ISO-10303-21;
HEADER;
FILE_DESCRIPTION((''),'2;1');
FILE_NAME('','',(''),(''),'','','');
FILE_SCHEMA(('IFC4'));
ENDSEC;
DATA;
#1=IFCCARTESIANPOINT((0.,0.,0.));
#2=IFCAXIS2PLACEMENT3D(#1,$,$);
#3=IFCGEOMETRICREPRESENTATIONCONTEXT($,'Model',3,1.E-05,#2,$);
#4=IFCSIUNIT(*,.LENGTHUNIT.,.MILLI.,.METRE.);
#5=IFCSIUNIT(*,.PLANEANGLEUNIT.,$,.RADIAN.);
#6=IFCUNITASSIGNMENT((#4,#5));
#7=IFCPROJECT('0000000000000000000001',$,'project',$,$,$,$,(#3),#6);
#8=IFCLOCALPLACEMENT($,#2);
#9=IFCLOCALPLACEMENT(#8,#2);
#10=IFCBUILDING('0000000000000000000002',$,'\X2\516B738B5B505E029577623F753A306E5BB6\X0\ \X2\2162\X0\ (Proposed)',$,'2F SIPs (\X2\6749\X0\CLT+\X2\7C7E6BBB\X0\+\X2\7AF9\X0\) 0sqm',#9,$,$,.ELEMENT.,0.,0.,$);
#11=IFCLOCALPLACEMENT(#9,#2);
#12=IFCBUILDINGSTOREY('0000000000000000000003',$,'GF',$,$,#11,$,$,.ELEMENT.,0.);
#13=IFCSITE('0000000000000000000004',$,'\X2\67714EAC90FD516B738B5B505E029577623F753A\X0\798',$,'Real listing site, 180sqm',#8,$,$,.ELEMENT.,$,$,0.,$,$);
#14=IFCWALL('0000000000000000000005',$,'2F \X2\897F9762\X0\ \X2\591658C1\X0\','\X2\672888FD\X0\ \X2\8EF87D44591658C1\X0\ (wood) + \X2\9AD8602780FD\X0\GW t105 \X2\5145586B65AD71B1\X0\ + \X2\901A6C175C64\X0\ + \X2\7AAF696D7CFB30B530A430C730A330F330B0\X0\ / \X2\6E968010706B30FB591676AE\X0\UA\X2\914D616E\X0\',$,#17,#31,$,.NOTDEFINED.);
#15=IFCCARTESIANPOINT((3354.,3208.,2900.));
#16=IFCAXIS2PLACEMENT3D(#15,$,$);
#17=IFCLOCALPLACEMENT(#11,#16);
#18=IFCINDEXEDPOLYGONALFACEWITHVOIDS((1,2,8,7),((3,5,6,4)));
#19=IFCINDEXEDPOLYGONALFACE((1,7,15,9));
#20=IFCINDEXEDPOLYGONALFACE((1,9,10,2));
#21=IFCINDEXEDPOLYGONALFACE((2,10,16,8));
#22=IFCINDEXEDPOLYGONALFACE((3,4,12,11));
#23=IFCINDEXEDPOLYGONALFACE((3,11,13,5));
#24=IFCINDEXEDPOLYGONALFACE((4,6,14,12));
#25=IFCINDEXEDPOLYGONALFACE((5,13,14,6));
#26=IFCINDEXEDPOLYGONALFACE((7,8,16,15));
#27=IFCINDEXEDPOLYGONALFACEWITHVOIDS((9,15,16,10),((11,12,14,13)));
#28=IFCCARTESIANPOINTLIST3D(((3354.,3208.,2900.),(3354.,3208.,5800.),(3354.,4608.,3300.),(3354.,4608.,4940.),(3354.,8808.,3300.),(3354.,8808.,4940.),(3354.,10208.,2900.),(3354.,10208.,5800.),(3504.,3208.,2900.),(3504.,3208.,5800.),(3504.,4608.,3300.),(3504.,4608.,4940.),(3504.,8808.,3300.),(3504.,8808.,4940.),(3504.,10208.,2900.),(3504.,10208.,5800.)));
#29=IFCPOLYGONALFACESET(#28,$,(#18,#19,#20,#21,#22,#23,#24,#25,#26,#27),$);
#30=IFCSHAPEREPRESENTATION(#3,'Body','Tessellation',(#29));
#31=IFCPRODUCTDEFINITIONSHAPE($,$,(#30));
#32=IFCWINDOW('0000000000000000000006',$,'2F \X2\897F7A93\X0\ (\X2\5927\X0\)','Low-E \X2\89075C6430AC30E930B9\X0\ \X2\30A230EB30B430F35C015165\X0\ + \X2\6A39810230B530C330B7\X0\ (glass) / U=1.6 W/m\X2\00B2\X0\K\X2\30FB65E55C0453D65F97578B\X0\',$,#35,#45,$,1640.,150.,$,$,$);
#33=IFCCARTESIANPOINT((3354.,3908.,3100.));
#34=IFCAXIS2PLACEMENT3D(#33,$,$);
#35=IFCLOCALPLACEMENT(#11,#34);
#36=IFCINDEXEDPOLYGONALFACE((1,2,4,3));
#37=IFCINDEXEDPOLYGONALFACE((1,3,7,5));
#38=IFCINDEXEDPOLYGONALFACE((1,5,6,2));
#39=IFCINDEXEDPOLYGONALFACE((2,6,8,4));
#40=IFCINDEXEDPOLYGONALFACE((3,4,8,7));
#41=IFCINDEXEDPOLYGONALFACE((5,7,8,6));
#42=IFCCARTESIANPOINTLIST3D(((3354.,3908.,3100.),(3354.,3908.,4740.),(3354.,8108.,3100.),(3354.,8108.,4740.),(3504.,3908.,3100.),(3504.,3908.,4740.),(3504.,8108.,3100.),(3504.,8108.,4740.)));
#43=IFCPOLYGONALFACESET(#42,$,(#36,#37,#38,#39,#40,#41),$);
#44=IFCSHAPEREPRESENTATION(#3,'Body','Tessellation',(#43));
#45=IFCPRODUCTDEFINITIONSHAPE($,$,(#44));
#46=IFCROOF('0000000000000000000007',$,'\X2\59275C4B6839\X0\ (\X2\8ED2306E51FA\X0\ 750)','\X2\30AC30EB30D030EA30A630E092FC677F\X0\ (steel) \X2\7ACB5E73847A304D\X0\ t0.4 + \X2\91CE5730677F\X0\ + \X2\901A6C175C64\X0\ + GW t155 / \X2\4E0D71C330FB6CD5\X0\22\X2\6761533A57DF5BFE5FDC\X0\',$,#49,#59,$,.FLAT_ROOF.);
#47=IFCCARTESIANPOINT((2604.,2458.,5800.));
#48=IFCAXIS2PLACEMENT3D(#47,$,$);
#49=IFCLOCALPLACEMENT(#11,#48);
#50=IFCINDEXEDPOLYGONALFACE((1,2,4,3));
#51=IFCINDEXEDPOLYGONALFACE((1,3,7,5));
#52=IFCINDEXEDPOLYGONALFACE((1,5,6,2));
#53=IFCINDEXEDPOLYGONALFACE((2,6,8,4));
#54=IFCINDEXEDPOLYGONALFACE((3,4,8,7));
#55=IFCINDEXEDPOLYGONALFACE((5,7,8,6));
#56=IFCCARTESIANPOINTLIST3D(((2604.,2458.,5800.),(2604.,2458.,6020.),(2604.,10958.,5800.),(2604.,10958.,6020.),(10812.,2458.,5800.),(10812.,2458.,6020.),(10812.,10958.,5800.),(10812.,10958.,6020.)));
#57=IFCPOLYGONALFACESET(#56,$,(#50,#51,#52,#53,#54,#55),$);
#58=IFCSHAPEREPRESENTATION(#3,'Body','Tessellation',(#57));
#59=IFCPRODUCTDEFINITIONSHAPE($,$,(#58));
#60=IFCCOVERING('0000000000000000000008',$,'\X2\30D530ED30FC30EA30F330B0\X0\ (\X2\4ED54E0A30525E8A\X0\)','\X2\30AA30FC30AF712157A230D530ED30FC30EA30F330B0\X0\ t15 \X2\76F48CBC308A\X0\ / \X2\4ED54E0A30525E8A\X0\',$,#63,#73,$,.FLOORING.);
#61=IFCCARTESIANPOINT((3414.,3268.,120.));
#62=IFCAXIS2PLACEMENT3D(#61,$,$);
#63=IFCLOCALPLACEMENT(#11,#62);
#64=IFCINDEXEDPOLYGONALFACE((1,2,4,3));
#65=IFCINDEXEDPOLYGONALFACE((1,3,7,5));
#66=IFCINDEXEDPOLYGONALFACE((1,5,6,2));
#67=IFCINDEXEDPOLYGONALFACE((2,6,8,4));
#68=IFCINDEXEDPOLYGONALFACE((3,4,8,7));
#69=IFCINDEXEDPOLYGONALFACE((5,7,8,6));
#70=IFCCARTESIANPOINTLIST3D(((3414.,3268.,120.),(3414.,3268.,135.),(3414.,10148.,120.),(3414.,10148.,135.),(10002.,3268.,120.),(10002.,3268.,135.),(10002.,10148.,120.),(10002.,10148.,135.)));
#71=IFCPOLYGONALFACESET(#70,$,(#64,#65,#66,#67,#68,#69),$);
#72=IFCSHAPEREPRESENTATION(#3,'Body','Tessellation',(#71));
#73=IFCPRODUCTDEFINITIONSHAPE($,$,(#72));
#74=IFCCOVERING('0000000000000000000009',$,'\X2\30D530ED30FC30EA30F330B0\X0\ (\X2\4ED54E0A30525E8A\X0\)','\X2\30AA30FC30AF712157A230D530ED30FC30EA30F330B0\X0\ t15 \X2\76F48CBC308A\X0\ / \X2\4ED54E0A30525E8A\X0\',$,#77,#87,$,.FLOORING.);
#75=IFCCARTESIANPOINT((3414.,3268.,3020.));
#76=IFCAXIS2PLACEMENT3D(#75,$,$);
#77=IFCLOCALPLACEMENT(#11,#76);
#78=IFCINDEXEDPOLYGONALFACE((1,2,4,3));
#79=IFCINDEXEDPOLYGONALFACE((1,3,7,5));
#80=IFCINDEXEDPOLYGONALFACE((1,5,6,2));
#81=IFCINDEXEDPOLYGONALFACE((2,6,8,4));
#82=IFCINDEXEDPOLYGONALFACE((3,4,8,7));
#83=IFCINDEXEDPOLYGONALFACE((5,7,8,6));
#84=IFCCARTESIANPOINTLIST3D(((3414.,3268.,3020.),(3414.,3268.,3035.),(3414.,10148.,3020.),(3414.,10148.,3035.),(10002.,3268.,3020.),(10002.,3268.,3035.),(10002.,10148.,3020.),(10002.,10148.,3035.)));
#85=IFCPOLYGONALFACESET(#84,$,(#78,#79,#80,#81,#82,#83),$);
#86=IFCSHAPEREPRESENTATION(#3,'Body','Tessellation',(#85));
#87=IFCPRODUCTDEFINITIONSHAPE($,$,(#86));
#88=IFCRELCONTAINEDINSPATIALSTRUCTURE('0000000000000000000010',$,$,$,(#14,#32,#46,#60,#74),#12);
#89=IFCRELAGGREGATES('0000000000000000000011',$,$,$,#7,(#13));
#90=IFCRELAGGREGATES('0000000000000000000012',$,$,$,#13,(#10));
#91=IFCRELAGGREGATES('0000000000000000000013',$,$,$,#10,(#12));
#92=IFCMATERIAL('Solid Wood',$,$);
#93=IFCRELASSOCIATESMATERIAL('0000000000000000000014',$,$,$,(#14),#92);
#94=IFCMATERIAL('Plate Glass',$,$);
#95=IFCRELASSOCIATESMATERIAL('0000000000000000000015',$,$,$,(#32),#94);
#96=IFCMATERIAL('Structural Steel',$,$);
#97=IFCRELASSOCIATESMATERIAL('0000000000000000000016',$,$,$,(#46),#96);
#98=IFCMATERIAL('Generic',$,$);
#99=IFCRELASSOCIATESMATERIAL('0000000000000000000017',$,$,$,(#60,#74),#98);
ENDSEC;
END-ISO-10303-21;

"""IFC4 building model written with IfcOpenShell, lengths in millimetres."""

from ifc_helpers import new_model, si_unit, frame, frame_2d, origin, place, context, project, spatial, rectangle, extrude, material, element, fill, save


model = new_model("IFC4")

# Units and contexts
model_context = context("Model", 3, precision=1e-05, world=origin())
ifc_project = project(units=[si_unit("LENGTHUNIT", "METRE", prefix="MILLI"), si_unit("PLANEANGLEUNIT", "RADIAN")], contexts=[model_context])

# Site, building, storey
site_placement = place(None, origin())
site = spatial("IfcSite", under=ifc_project, at=site_placement, Name="東京都八王子市長房町798", ObjectType="Real listing site, 180sqm", CompositionType="ELEMENT", RefElevation=0.0)
building_placement = place(site_placement, origin())
building = spatial("IfcBuilding", under=site, at=building_placement, Name="八王子市長房町の家 Ⅲ (Proposed)", ObjectType="2F SIPs (杉CLT+籾殻+竹) 0sqm", CompositionType="ELEMENT", ElevationOfRefHeight=0.0, ElevationOfTerrain=0.0)
storey_placement = place(building_placement, origin())
storey = spatial("IfcBuildingStorey", under=building, at=storey_placement, Name="GF", CompositionType="ELEMENT", Elevation=0.0)

# Shared definitions
ifc_material_1 = material(Name="Solid Wood")

# Shared definitions
ifc_material_2 = material(Name="Plate Glass")

# Wall, opening, window
wall_1_placement = place(storey_placement, frame((3354.0, 3208.0, 2900.0)))
wall_1 = element("IfcWall", 1, at=wall_1_placement, inside=storey, material=ifc_material_1, Name="2F 西面 外壁", Description="木製 軸組外壁 (wood) + 高性能GW t105 充填断熱 + 通気層 + 窯業系サイディング / 準耐火・外皮UA配慮", PredefinedType="NOTDEFINED", context=model_context, shape_type="SweptSolid", body=[
    extrude(rectangle(XDim=150.0, YDim=7000.0, at=frame_2d((75.0, 3500.0))), frame((3354.0, 3208.0, 2900.0)), (0.0, 0.0, 1.0), 2900.0),
])
opening_1_placement = place(storey_placement, frame((3354.0, 3908.0, 3100.0)))
opening_1 = element("IfcOpeningElement", 2, at=opening_1_placement, cuts=wall_1, PredefinedType="NOTDEFINED", context=model_context, shape_type="SweptSolid", body=[
    extrude(rectangle(XDim=150.0, YDim=4200.0, at=frame_2d((75.0, 2100.0))), frame((3354.0, 3908.0, 3100.0)), (0.0, 0.0, 1.0), 1640.0),
])
window_1_placement = place(storey_placement, frame((3354.0, 3908.0, 3100.0)))
window_1 = element("IfcWindow", 3, at=window_1_placement, inside=storey, material=ifc_material_2, Name="2F 西窓 (大)", Description="Low-E 複層ガラス アルゴン封入 + 樹脂サッシ (glass) / U=1.6 W/m²K・日射取得型", OverallHeight=1640.0, OverallWidth=150.0, context=model_context, shape_type="SweptSolid", body=[
    extrude(rectangle(XDim=150.0, YDim=4200.0, at=frame_2d((75.0, 2100.0))), frame((3354.0, 3908.0, 3100.0)), (0.0, 0.0, 1.0), 1640.0),
])
fill(opening_1, window_1)

# Roof
ifc_material_3 = material(Name="Structural Steel")
roof_placement = place(storey_placement, frame((2604.0, 2458.0, 5800.0)))
element("IfcRoof", 4, at=roof_placement, inside=storey, material=ifc_material_3, Name="大屋根 (軒の出 750)", Description="ガルバリウム鋼板 (steel) 立平葺き t0.4 + 野地板 + 通気層 + GW t155 / 不燃・法22条区域対応", PredefinedType="FLAT_ROOF", context=model_context, shape_type="SweptSolid", body=[
    extrude(rectangle(XDim=8208.0, YDim=8500.0, at=frame_2d((4104.0, 4250.0))), frame((2604.0, 2458.0, 5800.0)), (0.0, 0.0, 1.0), 220.0),
])

# Coverings
ifc_material_4 = material(Name="Generic")
covering_1_placement = place(storey_placement, frame((3414.0, 3268.0, 120.0)))
element("IfcCovering", 5, at=covering_1_placement, inside=storey, material=ifc_material_4, Name="フローリング (仕上げ床)", Description="オーク無垢フローリング t15 直貼り / 仕上げ床", PredefinedType="FLOORING", context=model_context, shape_type="SweptSolid", body=[
    extrude(rectangle(XDim=6588.0, YDim=6880.0, at=frame_2d((3294.0, 3440.0))), frame((3414.0, 3268.0, 120.0)), (0.0, 0.0, 1.0), 15.0),
])
covering_2_placement = place(storey_placement, frame((3414.0, 3268.0, 3020.0)))
element("IfcCovering", 6, at=covering_2_placement, inside=storey, material=ifc_material_4, Name="フローリング (仕上げ床)", Description="オーク無垢フローリング t15 直貼り / 仕上げ床", PredefinedType="FLOORING", context=model_context, shape_type="SweptSolid", body=[
    extrude(rectangle(XDim=6588.0, YDim=6880.0, at=frame_2d((3294.0, 3440.0))), frame((3414.0, 3268.0, 3020.0)), (0.0, 0.0, 1.0), 15.0),
])

save(model, "model.ifc")
